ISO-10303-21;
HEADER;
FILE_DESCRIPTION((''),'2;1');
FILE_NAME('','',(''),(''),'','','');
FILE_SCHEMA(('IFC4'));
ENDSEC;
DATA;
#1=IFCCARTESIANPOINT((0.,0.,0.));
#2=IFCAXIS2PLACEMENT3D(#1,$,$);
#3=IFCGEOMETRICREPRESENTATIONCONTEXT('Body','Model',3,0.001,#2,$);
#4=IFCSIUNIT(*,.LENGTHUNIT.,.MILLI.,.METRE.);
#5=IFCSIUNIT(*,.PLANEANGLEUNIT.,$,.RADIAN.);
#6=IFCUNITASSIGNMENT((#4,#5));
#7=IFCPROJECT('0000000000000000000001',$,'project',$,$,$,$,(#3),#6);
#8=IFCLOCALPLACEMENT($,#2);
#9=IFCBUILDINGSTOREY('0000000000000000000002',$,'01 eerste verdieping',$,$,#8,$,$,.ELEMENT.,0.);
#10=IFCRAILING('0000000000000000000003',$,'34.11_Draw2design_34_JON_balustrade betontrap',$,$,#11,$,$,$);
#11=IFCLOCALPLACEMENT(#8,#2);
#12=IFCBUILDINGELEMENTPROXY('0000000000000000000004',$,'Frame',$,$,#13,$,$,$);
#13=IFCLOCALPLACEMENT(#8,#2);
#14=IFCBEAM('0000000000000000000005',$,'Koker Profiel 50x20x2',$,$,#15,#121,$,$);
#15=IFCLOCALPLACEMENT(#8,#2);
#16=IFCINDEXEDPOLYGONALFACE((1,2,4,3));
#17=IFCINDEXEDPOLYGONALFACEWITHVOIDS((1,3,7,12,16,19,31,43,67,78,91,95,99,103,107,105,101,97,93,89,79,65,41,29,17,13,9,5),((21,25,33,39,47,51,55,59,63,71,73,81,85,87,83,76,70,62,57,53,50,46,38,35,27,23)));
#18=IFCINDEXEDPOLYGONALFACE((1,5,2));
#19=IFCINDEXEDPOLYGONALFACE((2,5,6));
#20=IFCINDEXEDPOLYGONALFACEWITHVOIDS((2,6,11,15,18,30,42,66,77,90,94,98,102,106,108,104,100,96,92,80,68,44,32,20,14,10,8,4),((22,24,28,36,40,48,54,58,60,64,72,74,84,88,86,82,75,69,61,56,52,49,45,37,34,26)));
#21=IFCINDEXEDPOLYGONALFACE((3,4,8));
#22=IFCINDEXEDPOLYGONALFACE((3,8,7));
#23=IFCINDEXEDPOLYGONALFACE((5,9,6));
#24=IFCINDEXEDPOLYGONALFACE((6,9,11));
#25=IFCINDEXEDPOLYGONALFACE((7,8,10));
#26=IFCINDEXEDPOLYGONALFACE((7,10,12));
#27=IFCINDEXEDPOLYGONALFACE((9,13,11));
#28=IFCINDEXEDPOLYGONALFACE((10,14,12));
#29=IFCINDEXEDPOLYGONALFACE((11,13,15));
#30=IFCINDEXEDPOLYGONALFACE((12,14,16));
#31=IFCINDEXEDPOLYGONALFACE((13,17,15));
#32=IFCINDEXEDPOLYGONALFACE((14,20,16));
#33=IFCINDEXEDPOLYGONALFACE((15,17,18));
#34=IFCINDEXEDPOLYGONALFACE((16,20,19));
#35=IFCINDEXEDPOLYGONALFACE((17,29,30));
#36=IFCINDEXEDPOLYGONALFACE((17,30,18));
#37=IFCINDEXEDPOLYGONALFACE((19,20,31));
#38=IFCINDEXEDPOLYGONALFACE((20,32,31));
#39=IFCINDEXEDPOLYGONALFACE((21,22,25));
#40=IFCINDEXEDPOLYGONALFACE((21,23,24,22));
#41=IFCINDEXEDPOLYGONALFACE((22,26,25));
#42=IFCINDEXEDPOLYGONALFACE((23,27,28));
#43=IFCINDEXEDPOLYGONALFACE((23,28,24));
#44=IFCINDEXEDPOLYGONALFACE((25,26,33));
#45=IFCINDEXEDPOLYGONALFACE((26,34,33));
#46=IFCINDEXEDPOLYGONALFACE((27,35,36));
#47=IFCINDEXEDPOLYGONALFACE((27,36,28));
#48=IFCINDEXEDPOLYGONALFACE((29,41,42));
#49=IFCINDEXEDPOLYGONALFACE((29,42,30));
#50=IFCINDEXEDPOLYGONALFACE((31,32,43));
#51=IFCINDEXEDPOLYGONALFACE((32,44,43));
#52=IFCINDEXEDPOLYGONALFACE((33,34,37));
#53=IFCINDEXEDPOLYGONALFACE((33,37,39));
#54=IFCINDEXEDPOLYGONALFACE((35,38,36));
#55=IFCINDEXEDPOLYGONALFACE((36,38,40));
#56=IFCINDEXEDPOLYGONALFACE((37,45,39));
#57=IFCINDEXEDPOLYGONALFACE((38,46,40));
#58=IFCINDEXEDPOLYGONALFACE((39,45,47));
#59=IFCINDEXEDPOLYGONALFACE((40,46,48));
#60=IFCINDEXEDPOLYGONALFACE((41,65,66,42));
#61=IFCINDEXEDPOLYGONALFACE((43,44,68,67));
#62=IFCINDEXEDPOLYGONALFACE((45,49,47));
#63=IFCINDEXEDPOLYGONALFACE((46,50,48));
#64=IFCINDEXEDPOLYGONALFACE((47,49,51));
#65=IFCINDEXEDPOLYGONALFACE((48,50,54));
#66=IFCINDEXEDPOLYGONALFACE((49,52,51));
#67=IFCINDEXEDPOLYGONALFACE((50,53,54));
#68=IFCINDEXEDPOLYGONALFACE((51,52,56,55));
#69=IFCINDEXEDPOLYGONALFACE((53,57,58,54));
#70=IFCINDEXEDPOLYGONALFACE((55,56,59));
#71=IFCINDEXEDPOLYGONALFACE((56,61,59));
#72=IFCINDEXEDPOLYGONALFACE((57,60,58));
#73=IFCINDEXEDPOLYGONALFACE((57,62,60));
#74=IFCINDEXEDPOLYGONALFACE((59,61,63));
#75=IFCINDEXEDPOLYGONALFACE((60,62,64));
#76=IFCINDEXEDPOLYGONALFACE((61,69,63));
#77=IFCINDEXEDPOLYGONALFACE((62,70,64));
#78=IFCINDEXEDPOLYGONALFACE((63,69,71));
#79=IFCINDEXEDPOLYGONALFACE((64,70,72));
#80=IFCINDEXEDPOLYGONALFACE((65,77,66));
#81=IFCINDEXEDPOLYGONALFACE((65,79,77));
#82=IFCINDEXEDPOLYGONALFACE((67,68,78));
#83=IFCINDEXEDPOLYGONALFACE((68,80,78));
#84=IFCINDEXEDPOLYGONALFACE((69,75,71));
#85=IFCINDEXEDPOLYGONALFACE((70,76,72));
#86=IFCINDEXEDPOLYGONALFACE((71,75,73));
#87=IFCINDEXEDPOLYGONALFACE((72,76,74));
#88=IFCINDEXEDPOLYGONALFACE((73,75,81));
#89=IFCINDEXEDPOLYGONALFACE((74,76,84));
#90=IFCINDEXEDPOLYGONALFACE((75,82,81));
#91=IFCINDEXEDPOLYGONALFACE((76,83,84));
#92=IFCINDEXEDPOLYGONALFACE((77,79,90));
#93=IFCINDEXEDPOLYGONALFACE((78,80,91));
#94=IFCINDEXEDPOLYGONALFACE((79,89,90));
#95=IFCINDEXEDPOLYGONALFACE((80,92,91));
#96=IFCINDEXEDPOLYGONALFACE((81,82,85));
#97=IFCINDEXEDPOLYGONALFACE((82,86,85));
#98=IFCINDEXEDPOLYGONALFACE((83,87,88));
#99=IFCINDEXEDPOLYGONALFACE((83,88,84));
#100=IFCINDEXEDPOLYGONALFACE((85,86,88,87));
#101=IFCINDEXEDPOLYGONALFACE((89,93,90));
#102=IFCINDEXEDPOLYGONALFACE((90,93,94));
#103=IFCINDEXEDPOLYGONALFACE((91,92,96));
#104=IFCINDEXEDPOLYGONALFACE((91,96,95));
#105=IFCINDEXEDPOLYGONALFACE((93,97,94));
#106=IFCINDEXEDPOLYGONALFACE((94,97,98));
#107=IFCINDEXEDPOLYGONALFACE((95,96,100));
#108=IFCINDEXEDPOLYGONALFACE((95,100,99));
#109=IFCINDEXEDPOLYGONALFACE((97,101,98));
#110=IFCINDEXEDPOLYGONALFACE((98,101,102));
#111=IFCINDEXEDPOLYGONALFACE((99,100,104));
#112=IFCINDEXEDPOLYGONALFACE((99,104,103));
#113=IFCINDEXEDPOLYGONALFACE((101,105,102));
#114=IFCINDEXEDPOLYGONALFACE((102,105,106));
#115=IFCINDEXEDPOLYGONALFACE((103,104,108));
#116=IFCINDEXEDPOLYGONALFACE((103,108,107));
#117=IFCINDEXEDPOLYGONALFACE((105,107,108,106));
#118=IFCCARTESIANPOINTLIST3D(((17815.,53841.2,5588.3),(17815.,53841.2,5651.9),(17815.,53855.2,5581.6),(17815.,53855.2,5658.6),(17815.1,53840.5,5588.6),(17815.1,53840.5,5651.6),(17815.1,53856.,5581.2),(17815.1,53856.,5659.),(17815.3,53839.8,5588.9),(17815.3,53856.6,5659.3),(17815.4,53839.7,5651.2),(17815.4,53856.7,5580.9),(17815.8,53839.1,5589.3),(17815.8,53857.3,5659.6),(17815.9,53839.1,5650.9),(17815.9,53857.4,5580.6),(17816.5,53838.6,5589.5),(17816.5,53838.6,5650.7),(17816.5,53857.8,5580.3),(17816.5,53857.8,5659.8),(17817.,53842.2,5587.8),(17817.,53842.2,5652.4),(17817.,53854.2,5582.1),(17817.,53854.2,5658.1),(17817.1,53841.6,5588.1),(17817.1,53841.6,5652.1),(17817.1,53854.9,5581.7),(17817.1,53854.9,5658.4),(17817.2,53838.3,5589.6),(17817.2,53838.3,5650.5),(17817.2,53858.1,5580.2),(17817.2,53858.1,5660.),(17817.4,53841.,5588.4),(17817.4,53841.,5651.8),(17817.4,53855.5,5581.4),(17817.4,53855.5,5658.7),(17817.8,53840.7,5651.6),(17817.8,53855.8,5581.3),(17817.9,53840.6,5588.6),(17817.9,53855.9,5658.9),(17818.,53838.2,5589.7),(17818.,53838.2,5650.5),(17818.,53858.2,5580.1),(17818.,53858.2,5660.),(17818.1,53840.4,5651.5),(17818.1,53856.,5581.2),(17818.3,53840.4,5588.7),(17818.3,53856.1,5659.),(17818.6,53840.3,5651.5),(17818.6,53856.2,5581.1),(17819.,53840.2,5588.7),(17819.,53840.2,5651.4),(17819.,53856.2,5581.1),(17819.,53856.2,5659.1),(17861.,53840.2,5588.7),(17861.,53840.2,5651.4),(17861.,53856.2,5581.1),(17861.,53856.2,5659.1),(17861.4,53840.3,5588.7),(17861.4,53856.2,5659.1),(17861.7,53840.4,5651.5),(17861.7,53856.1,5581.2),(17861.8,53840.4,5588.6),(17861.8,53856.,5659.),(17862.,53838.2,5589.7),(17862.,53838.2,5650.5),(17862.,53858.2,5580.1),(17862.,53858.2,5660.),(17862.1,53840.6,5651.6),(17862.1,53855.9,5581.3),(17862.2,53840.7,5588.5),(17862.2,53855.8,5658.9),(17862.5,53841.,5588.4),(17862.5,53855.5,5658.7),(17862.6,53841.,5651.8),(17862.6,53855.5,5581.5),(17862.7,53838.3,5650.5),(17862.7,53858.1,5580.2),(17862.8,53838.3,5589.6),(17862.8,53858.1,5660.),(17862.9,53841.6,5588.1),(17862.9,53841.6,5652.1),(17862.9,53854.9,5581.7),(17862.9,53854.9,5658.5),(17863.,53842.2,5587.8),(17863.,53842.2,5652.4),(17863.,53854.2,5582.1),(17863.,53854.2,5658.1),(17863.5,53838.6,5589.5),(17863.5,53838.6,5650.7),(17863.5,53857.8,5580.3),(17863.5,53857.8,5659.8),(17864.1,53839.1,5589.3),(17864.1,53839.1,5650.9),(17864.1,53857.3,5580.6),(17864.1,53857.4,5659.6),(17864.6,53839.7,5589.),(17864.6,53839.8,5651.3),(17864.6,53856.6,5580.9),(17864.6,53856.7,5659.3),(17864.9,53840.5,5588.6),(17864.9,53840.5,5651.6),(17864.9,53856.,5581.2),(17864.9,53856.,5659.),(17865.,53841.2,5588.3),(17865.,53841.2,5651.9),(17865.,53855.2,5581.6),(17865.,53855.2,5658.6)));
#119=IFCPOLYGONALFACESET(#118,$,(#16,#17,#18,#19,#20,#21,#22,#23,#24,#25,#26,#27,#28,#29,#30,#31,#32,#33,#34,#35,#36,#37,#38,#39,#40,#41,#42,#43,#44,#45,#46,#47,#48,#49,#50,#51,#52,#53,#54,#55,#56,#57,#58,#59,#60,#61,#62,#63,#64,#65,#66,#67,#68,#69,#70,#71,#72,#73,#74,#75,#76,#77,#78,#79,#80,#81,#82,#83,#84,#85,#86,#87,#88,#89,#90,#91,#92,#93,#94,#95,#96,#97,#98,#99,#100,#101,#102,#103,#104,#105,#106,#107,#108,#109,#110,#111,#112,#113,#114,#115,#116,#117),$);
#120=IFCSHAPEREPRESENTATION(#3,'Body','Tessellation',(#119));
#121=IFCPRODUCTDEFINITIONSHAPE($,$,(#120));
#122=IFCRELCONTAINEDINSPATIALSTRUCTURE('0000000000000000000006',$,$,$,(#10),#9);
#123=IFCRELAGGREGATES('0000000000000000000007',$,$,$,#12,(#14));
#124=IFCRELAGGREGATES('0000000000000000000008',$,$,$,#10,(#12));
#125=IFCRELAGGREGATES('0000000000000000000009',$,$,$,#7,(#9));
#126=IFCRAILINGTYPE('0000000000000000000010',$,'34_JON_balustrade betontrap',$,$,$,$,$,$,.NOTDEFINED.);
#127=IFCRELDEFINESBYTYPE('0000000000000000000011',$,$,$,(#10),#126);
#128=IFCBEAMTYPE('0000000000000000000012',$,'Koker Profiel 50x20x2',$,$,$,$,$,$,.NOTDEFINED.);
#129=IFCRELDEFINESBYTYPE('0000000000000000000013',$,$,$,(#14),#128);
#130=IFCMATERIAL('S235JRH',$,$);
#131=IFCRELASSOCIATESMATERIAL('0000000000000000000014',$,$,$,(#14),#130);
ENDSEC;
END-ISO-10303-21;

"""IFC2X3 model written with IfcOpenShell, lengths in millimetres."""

from ifc_helpers import new_model, si_unit, frame, origin, origin_2d, place, context, project, spatial, hollow_rectangle, extrude, clip, halfspace, source, transform, mapped, material, type_object, element, aggregate, save


model = new_model("IFC2X3")

# Units and contexts
model_context = context("Model", 3, precision=0.001, world=origin(), identifier="Body")
ifc_project = project(units=[si_unit("LENGTHUNIT", "METRE", prefix="MILLI"), si_unit("PLANEANGLEUNIT", "RADIAN")], contexts=[model_context])

# Storey
storey_placement = place(None, origin())
storey = spatial("IfcBuildingStorey", under=ifc_project, at=storey_placement, Name="01 eerste verdieping", CompositionType="ELEMENT", Elevation=0.0)

# Railing, building element proxy, beam
railing_type = type_object("IfcRailingType", Name="34_JON_balustrade betontrap")
railing_placement = place(storey_placement, frame((-2939.5, 7875.7, -43304.2), z_axis=(0.0, 0.0, 1.0), x_axis=(1.0, 0.0, 0.0)))
railing = element("IfcRailing", 1, at=railing_placement, inside=storey, type_object=railing_type, Name="34.11_Draw2design_34_JON_balustrade betontrap")
ifc_material_1 = material(Name="S235JRH")
proxy_1_placement = place(railing_placement, origin())
proxy_1 = element("IfcBuildingElementProxy", 2, at=proxy_1_placement, Name="Frame")
beam_type_1 = type_object("IfcBeamType", Name="Koker Profiel 50x20x2")
shared_shape_1 = source(origin(), model_context, "Body", "Clipping", [
    clip(clip(extrude(hollow_rectangle(XDim=20.0, YDim=50.0, WallThickness=2.0, InnerFilletRadius=2.0, OuterFilletRadius=3.0, at=origin_2d()), origin(), (0.0, 0.0, -1.0), 79.9), halfspace(frame((-10.0, 25.0, -9.6), z_axis=(-0.430948, 0.0, 0.902377), x_axis=(0.902377, 0.0, 0.430948)), False)), halfspace(frame((-10.0, -25.0, -70.3), z_axis=(-0.430948, 0.0, -0.902377), x_axis=(-0.902377, 0.0, 0.430948)), False)),
])
beam_1_placement = place(proxy_1_placement, frame((20779.5, 45972.5, 48964.2), z_axis=(0.0, 0.0, 1.0), x_axis=(0.0, 1.0, 0.0)))
beam_1 = element("IfcBeam", 3, at=beam_1_placement, type_object=beam_type_1, material=ifc_material_1, Name="Koker Profiel 50x20x2", context=model_context, shape_type="MappedRepresentation", body=[
    mapped(shared_shape_1, transform((0.0, 0.0, 0.0), scale=1.0)),
])
aggregate(proxy_1, [beam_1])
aggregate(railing, [proxy_1])

save(model, "model.ifc")
